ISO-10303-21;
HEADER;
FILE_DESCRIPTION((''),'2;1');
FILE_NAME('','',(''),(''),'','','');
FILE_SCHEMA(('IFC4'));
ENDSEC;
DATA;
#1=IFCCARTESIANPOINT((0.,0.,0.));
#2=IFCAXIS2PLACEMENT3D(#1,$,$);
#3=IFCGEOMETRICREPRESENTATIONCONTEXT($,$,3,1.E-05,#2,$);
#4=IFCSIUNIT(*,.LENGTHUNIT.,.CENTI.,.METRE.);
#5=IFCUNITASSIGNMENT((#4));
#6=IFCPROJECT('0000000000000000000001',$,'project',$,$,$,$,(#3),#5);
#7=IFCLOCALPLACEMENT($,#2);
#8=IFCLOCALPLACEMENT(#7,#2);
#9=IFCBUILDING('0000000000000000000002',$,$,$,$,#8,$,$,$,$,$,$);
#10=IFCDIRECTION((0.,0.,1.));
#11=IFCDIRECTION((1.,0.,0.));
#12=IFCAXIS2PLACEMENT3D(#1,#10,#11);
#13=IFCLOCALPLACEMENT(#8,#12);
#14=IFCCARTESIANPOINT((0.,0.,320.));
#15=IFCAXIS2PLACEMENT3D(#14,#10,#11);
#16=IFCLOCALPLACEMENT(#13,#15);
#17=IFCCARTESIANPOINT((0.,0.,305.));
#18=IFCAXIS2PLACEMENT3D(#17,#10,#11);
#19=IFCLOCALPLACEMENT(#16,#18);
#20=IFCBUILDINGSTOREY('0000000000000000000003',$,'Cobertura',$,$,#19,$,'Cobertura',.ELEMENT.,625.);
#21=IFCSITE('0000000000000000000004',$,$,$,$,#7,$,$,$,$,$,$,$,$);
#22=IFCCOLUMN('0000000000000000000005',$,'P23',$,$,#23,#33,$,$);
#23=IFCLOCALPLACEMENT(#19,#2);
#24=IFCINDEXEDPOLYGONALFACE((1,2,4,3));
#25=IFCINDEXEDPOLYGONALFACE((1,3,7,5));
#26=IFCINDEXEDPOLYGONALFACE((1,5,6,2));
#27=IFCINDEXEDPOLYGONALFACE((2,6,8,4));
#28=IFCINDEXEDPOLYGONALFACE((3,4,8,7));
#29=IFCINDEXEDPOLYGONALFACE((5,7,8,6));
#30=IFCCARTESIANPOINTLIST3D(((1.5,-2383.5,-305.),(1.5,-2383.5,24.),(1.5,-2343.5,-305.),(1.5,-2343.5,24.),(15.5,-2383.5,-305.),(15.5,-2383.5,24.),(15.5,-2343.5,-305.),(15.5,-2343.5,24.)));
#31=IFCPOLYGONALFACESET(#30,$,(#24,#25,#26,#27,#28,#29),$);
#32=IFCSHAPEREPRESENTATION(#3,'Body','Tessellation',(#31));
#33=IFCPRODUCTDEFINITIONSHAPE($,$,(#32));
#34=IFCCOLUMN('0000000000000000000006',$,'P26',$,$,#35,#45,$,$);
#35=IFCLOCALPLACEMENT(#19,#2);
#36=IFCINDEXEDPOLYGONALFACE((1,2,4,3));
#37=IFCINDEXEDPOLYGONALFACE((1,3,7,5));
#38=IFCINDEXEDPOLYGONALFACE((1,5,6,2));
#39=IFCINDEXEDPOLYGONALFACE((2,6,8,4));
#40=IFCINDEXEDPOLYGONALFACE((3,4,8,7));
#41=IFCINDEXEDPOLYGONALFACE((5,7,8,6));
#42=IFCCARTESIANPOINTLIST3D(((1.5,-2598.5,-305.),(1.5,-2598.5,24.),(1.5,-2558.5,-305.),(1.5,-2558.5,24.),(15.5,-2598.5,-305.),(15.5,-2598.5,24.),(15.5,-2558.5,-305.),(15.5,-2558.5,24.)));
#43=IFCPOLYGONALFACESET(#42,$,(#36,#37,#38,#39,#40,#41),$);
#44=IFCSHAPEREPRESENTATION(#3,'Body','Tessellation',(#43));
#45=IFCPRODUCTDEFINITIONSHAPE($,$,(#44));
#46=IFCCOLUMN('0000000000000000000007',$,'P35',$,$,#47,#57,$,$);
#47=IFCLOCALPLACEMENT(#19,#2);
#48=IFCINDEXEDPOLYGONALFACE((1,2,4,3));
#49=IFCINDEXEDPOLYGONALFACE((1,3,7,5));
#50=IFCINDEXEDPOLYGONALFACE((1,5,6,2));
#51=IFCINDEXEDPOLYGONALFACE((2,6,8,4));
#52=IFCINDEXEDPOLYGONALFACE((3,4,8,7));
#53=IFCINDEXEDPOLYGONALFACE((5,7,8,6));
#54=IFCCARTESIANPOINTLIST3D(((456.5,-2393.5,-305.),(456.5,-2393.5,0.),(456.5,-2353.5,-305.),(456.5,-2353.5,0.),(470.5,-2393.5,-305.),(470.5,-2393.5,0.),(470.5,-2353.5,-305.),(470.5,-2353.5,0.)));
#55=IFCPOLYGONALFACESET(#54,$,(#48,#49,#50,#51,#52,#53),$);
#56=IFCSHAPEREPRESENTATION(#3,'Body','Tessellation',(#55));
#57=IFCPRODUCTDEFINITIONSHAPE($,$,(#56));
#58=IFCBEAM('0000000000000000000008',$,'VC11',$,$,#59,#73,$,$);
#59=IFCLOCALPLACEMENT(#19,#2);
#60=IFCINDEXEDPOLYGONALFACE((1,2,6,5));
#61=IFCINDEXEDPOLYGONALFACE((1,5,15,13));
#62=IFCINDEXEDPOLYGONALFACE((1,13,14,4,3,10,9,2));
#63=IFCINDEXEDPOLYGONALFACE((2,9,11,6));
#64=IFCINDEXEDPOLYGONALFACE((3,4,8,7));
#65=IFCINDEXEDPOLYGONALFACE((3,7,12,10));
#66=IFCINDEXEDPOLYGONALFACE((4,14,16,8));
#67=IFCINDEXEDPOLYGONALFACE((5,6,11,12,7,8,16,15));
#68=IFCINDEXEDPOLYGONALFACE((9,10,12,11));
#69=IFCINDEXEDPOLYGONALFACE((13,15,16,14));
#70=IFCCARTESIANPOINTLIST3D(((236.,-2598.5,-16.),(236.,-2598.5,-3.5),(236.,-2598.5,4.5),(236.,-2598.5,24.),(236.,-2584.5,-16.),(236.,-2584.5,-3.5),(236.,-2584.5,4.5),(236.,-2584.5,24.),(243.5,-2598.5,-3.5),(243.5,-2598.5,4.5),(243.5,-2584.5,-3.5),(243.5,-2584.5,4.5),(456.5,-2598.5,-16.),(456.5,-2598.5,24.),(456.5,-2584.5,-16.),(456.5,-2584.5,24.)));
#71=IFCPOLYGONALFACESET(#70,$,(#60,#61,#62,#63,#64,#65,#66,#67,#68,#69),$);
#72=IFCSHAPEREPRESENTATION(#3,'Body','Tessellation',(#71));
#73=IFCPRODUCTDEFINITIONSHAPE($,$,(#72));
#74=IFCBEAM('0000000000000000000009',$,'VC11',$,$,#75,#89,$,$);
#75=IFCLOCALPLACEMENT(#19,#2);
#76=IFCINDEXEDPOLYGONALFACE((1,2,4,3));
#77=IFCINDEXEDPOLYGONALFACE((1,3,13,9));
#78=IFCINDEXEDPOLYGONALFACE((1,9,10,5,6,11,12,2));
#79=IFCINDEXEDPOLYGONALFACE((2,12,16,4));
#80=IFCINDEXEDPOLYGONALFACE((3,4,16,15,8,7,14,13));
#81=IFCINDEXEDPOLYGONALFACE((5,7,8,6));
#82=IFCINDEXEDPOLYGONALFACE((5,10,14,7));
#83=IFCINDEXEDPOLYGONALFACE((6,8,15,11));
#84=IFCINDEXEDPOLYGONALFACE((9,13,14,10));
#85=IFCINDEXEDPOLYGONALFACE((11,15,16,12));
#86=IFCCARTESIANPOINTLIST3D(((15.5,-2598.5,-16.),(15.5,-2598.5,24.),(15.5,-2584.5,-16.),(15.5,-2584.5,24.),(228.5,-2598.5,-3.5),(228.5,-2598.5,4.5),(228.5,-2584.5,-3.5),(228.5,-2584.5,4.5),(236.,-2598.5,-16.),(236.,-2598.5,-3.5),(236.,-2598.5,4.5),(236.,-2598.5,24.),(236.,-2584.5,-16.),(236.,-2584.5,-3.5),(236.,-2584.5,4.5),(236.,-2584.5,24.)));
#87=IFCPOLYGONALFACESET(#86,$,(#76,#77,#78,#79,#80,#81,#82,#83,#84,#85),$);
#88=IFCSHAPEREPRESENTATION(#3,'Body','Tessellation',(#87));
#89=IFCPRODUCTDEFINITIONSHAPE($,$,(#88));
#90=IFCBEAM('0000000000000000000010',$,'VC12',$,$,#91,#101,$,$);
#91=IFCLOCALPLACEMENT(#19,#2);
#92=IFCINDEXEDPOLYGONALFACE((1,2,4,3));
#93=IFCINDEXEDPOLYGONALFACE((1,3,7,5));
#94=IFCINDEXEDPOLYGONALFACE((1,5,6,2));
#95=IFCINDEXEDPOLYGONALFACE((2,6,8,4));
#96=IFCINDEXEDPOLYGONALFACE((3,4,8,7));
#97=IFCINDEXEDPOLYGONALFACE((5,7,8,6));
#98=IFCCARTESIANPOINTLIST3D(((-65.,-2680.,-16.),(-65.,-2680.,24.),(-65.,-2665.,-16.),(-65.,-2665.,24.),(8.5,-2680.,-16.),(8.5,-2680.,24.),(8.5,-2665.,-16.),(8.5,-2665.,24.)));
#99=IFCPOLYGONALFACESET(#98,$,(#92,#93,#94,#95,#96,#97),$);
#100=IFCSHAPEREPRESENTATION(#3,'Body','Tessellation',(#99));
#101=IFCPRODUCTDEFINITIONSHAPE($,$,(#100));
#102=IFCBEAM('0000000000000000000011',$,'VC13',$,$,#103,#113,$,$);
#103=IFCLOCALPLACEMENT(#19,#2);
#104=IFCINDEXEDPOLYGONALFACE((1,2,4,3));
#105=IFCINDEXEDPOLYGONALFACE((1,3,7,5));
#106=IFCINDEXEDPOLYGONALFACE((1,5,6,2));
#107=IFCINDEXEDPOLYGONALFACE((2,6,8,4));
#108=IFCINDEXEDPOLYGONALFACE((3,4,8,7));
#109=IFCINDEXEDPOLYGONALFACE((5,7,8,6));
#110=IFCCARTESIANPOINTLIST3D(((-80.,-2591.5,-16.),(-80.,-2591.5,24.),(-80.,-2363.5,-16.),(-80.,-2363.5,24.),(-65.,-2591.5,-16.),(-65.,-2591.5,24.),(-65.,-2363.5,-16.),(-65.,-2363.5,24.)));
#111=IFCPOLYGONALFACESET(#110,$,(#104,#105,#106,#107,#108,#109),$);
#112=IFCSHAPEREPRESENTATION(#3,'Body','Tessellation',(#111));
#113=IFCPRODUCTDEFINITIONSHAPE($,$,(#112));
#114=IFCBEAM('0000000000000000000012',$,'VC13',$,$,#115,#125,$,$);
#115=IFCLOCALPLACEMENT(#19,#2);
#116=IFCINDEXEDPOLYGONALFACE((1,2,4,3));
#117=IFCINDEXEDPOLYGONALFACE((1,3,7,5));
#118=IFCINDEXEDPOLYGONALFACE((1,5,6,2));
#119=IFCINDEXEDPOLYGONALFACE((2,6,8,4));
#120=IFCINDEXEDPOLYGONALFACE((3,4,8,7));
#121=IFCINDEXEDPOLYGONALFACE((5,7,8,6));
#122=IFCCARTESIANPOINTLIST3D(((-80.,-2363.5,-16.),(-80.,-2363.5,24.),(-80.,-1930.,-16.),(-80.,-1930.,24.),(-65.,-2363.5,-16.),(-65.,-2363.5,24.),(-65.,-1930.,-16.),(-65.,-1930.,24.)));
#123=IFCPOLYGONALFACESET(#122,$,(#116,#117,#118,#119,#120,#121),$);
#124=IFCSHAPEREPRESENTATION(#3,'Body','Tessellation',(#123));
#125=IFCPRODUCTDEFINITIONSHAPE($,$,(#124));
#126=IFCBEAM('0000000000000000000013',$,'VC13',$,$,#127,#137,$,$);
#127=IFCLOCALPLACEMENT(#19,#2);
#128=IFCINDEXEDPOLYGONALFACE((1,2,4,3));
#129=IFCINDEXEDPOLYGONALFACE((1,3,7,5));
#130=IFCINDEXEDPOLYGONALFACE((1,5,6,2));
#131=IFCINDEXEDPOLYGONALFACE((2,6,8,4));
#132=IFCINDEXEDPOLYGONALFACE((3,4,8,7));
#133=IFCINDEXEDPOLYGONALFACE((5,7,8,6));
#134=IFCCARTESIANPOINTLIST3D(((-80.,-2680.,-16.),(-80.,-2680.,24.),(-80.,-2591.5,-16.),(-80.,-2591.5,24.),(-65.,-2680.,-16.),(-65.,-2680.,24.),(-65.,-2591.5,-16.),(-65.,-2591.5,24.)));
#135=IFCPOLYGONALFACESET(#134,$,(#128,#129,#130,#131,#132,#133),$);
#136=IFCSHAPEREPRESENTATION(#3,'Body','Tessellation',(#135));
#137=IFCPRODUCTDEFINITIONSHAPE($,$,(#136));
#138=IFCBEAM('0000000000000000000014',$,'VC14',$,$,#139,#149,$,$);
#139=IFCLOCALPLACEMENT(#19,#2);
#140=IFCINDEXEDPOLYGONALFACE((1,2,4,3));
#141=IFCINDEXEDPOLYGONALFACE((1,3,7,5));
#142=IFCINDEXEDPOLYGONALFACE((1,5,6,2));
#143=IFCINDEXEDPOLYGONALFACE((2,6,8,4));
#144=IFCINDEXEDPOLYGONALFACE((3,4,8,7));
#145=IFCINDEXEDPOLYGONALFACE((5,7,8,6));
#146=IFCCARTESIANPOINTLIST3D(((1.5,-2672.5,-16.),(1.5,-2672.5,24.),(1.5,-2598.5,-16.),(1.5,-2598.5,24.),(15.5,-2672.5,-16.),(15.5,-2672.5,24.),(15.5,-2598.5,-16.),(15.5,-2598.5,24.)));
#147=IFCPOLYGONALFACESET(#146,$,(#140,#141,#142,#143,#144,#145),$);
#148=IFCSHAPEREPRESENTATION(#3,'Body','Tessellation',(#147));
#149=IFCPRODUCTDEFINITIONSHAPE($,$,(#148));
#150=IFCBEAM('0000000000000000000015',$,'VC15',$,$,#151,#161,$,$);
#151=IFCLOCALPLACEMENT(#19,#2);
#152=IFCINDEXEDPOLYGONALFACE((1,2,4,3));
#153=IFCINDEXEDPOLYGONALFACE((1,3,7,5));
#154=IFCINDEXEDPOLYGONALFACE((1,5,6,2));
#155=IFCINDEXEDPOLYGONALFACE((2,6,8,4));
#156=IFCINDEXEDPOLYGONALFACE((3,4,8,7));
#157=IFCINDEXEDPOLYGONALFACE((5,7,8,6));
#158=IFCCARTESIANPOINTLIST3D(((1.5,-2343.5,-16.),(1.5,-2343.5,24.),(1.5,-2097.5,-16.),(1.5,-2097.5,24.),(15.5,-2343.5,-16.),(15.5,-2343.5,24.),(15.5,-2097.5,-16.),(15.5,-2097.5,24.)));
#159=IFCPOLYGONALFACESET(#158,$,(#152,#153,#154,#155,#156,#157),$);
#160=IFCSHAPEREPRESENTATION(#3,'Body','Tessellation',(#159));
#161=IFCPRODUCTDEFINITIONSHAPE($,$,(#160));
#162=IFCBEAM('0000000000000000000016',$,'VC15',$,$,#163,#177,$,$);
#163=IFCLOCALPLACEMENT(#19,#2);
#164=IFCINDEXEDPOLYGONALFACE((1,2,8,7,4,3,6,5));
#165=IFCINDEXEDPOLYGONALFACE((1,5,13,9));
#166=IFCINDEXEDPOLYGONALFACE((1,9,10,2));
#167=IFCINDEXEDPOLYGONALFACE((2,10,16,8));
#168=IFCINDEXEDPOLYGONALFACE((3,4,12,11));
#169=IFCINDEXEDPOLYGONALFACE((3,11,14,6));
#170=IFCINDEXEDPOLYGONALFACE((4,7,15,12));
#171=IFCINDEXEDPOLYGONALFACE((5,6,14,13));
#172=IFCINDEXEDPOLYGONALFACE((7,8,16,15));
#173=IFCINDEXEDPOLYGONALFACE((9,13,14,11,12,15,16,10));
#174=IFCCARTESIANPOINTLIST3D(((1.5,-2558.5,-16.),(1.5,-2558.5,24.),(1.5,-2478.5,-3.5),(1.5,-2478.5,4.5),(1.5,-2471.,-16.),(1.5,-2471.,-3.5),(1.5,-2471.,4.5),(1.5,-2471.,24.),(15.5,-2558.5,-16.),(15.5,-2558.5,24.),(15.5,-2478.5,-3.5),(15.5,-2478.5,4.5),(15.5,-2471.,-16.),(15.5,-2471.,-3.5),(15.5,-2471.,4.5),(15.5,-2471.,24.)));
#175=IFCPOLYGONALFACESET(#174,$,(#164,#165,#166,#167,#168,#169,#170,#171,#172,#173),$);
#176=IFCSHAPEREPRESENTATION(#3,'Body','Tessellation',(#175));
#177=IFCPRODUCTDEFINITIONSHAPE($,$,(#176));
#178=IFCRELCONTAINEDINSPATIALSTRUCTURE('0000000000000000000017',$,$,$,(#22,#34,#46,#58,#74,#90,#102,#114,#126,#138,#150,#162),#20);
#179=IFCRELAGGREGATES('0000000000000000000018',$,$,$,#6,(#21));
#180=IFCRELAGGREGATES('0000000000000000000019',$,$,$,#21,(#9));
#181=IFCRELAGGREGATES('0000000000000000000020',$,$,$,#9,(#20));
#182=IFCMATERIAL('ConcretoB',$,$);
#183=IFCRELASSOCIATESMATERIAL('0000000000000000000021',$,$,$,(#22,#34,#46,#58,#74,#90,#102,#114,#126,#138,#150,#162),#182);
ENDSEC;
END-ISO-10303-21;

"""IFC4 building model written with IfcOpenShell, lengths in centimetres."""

from ifc_helpers import new_model, si_unit, frame, origin, origin_with_axes, place, context, project, spatial, polyline, outline, extrude, material, element, save


model = new_model("IFC4")

# Units and contexts
context_of_model = context(None, 3, precision=1e-05, world=origin())
ifc_project = project(units=[si_unit("LENGTHUNIT", "METRE", prefix="CENTI")], contexts=[context_of_model])

# Site, building, storey
site_placement = place(None, origin())
site = spatial("IfcSite", under=ifc_project, at=site_placement)
building_placement = place(site_placement, origin())
building = spatial("IfcBuilding", under=site, at=building_placement)
placement_1 = place(building_placement, origin_with_axes())
placement_2 = place(placement_1, frame((0.0, 0.0, 320.0), z_axis=(0.0, 0.0, 1.0), x_axis=(1.0, 0.0, 0.0)))
storey_placement = place(placement_2, frame((0.0, 0.0, 305.0), z_axis=(0.0, 0.0, 1.0), x_axis=(1.0, 0.0, 0.0)))
storey = spatial("IfcBuildingStorey", under=building, at=storey_placement, Name="Cobertura", LongName="Cobertura", CompositionType="ELEMENT", Elevation=625.0)

# Columns
ifc_material = material(Name="ConcretoB")
for number, where, z_axis, x_axis, name in (
    (1, (8.5, -2363.5, 24.0), (0.0, 0.0, 1.0), (1.0, 0.0, 0.0), "P23"),
    (2, (8.5, -2578.5, 24.0), (0.0, 0.0, 1.0), (1.0, 0.0, 0.0), "P26"),
):
    element("IfcColumn", number, at=place(storey_placement, frame(where, z_axis=z_axis, x_axis=x_axis)), inside=storey, material=ifc_material, Name=name, context=context_of_model, shape_type="SolidModel", body=[
        extrude(outline(polyline([(-7.0, -20.0), (7.0, -20.0), (7.0, 20.0), (-7.0, 20.0), (-7.0, -20.0)])), frame((0.0, 0.0, 0.0), z_axis=(0.0, 0.0, 1.0), x_axis=(1.0, 0.0, 0.0)), (0.0, 0.0, -1.0), 329.0),
    ])
column_placement = place(storey_placement, frame((463.5, -2373.5, 0.0), z_axis=(0.0, 0.0, 1.0), x_axis=(1.0, 0.0, 0.0)))
element("IfcColumn", 3, at=column_placement, inside=storey, material=ifc_material, Name="P35", context=context_of_model, shape_type="SolidModel", body=[
    extrude(outline(polyline([(-7.0, -20.0), (7.0, -20.0), (7.0, 20.0), (-7.0, 20.0), (-7.0, -20.0)])), origin_with_axes(), (0.0, 0.0, -1.0), 305.0),
])

# Beams, openings
beam_1_placement = place(storey_placement, frame((346.25, -2591.5, 24.0), z_axis=(0.0, 0.0, 1.0), x_axis=(1.0, 0.0, 0.0)))
beam_1 = element("IfcBeam", 4, at=beam_1_placement, inside=storey, material=ifc_material, Name="VC11", context=context_of_model, shape_type="SolidModel", body=[
    extrude(outline(polyline([(-7.0, -20.0), (7.0, -20.0), (7.0, 20.0), (-7.0, 20.0), (-7.0, -20.0)])), frame((-110.25, 0.0, -20.0), z_axis=(1.0, 0.0, 0.0), x_axis=(0.0, -1.0, 0.0)), (0.0, 0.0, 1.0), 220.5),
])
opening_1_placement = place(storey_placement, frame((0.0, 0.0, -625.0), z_axis=(0.0, 0.0, 1.0), x_axis=(1.0, 0.0, 0.0)))
element("IfcOpeningElement", 5, at=opening_1_placement, cuts=beam_1, material=ifc_material, context=context_of_model, shape_type="SweptSolid", body=[
    extrude(outline(polyline([(7.5, 4.0), (-7.5, 4.0), (-7.5, -4.0), (7.5, -4.0), (7.5, 4.0)])), frame((236.0, -2598.5, 625.5), z_axis=(0.0, 1.0, 0.0), x_axis=(-1.0, 0.0, 0.0)), (0.0, 0.0, 1.0), 14.0),
])
beam_2_placement = place(storey_placement, frame((125.75, -2591.5, 24.0), z_axis=(0.0, 0.0, 1.0), x_axis=(1.0, 0.0, 0.0)))
beam_2 = element("IfcBeam", 6, at=beam_2_placement, inside=storey, material=ifc_material, Name="VC11", context=context_of_model, shape_type="SolidModel", body=[
    extrude(outline(polyline([(-7.0, -20.0), (7.0, -20.0), (7.0, 20.0), (-7.0, 20.0), (-7.0, -20.0)])), frame((-110.25, 0.0, -20.0), z_axis=(1.0, 0.0, 0.0), x_axis=(0.0, -1.0, 0.0)), (0.0, 0.0, 1.0), 220.5),
])
opening_2_placement = place(storey_placement, frame((0.0, 0.0, -625.0), z_axis=(0.0, 0.0, 1.0), x_axis=(1.0, 0.0, 0.0)))
element("IfcOpeningElement", 7, at=opening_2_placement, cuts=beam_2, material=ifc_material, context=context_of_model, shape_type="SweptSolid", body=[
    extrude(outline(polyline([(7.5, 4.0), (-7.5, 4.0), (-7.5, -4.0), (7.5, -4.0), (7.5, 4.0)])), frame((236.0, -2598.5, 625.5), z_axis=(0.0, 1.0, 0.0), x_axis=(-1.0, 0.0, 0.0)), (0.0, 0.0, 1.0), 14.0),
])

# Beams
beam_3_placement = place(storey_placement, frame((-28.25, -2672.5, 24.0), z_axis=(0.0, 0.0, 1.0), x_axis=(1.0, 0.0, 0.0)))
element("IfcBeam", 8, at=beam_3_placement, inside=storey, material=ifc_material, Name="VC12", context=context_of_model, shape_type="SolidModel", body=[
    extrude(outline(polyline([(-7.5, -20.0), (7.5, -20.0), (7.5, 20.0), (-7.5, 20.0), (-7.5, -20.0)])), frame((-36.75, 0.0, -20.0), z_axis=(1.0, 0.0, 0.0), x_axis=(0.0, -1.0, 0.0)), (0.0, 0.0, 1.0), 73.5),
])
beam_4_placement = place(storey_placement, frame((-72.5, -2477.5, 24.0), z_axis=(0.0, 0.0, 1.0), x_axis=(1.0, 0.0, 0.0)))
element("IfcBeam", 9, at=beam_4_placement, inside=storey, material=ifc_material, Name="VC13", context=context_of_model, shape_type="SolidModel", body=[
    extrude(outline(polyline([(-7.5, -20.0), (7.5, -20.0), (7.5, 20.0), (-7.5, 20.0), (-7.5, -20.0)])), frame((0.0, -114.0, -20.0), z_axis=(0.0, 1.0, 0.0), x_axis=(1.0, 0.0, 0.0)), (0.0, 0.0, 1.0), 228.0),
])
beam_5_placement = place(storey_placement, frame((-72.5, -2146.75, 24.0), z_axis=(0.0, 0.0, 1.0), x_axis=(1.0, 0.0, 0.0)))
element("IfcBeam", 10, at=beam_5_placement, inside=storey, material=ifc_material, Name="VC13", context=context_of_model, shape_type="SolidModel", body=[
    extrude(outline(polyline([(-7.5, -20.0), (7.5, -20.0), (7.5, 20.0), (-7.5, 20.0), (-7.5, -20.0)])), frame((0.0, -216.75, -20.0), z_axis=(0.0, 1.0, 0.0), x_axis=(1.0, 0.0, 0.0)), (0.0, 0.0, 1.0), 433.5),
])
beam_6_placement = place(storey_placement, frame((-72.5, -2635.75, 24.0), z_axis=(0.0, 0.0, 1.0), x_axis=(1.0, 0.0, 0.0)))
element("IfcBeam", 11, at=beam_6_placement, inside=storey, material=ifc_material, Name="VC13", context=context_of_model, shape_type="SolidModel", body=[
    extrude(outline(polyline([(-7.5, -20.0), (7.5, -20.0), (7.5, 20.0), (-7.5, 20.0), (-7.5, -20.0)])), frame((0.0, -44.25, -20.0), z_axis=(0.0, 1.0, 0.0), x_axis=(1.0, 0.0, 0.0)), (0.0, 0.0, 1.0), 88.5),
])
beam_7_placement = place(storey_placement, frame((8.5, -2635.5, 24.0), z_axis=(0.0, 0.0, 1.0), x_axis=(1.0, 0.0, 0.0)))
element("IfcBeam", 12, at=beam_7_placement, inside=storey, material=ifc_material, Name="VC14", context=context_of_model, shape_type="SolidModel", body=[
    extrude(outline(polyline([(-7.0, -20.0), (7.0, -20.0), (7.0, 20.0), (-7.0, 20.0), (-7.0, -20.0)])), frame((0.0, -37.0, -20.0), z_axis=(0.0, 1.0, 0.0), x_axis=(1.0, 0.0, 0.0)), (0.0, 0.0, 1.0), 74.0),
])
beam_8_placement = place(storey_placement, frame((8.5, -2220.5, 24.0), z_axis=(0.0, 0.0, 1.0), x_axis=(1.0, 0.0, 0.0)))
element("IfcBeam", 13, at=beam_8_placement, inside=storey, material=ifc_material, Name="VC15", context=context_of_model, shape_type="SolidModel", body=[
    extrude(outline(polyline([(-7.0, -20.0), (7.0, -20.0), (7.0, 20.0), (-7.0, 20.0), (-7.0, -20.0)])), frame((0.0, -123.0, -20.0), z_axis=(0.0, 1.0, 0.0), x_axis=(1.0, 0.0, 0.0)), (0.0, 0.0, 1.0), 246.0),
])

# Beam, opening
beam_9_placement = place(storey_placement, frame((8.5, -2514.75, 24.0), z_axis=(0.0, 0.0, 1.0), x_axis=(1.0, 0.0, 0.0)))
beam_9 = element("IfcBeam", 14, at=beam_9_placement, inside=storey, material=ifc_material, Name="VC15", context=context_of_model, shape_type="SolidModel", body=[
    extrude(outline(polyline([(-7.0, -20.0), (7.0, -20.0), (7.0, 20.0), (-7.0, 20.0), (-7.0, -20.0)])), frame((0.0, -43.75, -20.0), z_axis=(0.0, 1.0, 0.0), x_axis=(1.0, 0.0, 0.0)), (0.0, 0.0, 1.0), 87.5),
])
opening_3_placement = place(storey_placement, frame((0.0, 0.0, -625.0), z_axis=(0.0, 0.0, 1.0), x_axis=(1.0, 0.0, 0.0)))
element("IfcOpeningElement", 15, at=opening_3_placement, cuts=beam_9, material=ifc_material, context=context_of_model, shape_type="SweptSolid", body=[
    extrude(outline(polyline([(7.5, 4.0), (-7.5, 4.0), (-7.5, -4.0), (7.5, -4.0), (7.5, 4.0)])), frame((15.5, -2471.0, 625.5), z_axis=(-1.0, 0.0, 0.0), x_axis=(0.0, -1.0, 0.0)), (0.0, 0.0, 1.0), 14.0),
])

save(model, "model.ifc")
